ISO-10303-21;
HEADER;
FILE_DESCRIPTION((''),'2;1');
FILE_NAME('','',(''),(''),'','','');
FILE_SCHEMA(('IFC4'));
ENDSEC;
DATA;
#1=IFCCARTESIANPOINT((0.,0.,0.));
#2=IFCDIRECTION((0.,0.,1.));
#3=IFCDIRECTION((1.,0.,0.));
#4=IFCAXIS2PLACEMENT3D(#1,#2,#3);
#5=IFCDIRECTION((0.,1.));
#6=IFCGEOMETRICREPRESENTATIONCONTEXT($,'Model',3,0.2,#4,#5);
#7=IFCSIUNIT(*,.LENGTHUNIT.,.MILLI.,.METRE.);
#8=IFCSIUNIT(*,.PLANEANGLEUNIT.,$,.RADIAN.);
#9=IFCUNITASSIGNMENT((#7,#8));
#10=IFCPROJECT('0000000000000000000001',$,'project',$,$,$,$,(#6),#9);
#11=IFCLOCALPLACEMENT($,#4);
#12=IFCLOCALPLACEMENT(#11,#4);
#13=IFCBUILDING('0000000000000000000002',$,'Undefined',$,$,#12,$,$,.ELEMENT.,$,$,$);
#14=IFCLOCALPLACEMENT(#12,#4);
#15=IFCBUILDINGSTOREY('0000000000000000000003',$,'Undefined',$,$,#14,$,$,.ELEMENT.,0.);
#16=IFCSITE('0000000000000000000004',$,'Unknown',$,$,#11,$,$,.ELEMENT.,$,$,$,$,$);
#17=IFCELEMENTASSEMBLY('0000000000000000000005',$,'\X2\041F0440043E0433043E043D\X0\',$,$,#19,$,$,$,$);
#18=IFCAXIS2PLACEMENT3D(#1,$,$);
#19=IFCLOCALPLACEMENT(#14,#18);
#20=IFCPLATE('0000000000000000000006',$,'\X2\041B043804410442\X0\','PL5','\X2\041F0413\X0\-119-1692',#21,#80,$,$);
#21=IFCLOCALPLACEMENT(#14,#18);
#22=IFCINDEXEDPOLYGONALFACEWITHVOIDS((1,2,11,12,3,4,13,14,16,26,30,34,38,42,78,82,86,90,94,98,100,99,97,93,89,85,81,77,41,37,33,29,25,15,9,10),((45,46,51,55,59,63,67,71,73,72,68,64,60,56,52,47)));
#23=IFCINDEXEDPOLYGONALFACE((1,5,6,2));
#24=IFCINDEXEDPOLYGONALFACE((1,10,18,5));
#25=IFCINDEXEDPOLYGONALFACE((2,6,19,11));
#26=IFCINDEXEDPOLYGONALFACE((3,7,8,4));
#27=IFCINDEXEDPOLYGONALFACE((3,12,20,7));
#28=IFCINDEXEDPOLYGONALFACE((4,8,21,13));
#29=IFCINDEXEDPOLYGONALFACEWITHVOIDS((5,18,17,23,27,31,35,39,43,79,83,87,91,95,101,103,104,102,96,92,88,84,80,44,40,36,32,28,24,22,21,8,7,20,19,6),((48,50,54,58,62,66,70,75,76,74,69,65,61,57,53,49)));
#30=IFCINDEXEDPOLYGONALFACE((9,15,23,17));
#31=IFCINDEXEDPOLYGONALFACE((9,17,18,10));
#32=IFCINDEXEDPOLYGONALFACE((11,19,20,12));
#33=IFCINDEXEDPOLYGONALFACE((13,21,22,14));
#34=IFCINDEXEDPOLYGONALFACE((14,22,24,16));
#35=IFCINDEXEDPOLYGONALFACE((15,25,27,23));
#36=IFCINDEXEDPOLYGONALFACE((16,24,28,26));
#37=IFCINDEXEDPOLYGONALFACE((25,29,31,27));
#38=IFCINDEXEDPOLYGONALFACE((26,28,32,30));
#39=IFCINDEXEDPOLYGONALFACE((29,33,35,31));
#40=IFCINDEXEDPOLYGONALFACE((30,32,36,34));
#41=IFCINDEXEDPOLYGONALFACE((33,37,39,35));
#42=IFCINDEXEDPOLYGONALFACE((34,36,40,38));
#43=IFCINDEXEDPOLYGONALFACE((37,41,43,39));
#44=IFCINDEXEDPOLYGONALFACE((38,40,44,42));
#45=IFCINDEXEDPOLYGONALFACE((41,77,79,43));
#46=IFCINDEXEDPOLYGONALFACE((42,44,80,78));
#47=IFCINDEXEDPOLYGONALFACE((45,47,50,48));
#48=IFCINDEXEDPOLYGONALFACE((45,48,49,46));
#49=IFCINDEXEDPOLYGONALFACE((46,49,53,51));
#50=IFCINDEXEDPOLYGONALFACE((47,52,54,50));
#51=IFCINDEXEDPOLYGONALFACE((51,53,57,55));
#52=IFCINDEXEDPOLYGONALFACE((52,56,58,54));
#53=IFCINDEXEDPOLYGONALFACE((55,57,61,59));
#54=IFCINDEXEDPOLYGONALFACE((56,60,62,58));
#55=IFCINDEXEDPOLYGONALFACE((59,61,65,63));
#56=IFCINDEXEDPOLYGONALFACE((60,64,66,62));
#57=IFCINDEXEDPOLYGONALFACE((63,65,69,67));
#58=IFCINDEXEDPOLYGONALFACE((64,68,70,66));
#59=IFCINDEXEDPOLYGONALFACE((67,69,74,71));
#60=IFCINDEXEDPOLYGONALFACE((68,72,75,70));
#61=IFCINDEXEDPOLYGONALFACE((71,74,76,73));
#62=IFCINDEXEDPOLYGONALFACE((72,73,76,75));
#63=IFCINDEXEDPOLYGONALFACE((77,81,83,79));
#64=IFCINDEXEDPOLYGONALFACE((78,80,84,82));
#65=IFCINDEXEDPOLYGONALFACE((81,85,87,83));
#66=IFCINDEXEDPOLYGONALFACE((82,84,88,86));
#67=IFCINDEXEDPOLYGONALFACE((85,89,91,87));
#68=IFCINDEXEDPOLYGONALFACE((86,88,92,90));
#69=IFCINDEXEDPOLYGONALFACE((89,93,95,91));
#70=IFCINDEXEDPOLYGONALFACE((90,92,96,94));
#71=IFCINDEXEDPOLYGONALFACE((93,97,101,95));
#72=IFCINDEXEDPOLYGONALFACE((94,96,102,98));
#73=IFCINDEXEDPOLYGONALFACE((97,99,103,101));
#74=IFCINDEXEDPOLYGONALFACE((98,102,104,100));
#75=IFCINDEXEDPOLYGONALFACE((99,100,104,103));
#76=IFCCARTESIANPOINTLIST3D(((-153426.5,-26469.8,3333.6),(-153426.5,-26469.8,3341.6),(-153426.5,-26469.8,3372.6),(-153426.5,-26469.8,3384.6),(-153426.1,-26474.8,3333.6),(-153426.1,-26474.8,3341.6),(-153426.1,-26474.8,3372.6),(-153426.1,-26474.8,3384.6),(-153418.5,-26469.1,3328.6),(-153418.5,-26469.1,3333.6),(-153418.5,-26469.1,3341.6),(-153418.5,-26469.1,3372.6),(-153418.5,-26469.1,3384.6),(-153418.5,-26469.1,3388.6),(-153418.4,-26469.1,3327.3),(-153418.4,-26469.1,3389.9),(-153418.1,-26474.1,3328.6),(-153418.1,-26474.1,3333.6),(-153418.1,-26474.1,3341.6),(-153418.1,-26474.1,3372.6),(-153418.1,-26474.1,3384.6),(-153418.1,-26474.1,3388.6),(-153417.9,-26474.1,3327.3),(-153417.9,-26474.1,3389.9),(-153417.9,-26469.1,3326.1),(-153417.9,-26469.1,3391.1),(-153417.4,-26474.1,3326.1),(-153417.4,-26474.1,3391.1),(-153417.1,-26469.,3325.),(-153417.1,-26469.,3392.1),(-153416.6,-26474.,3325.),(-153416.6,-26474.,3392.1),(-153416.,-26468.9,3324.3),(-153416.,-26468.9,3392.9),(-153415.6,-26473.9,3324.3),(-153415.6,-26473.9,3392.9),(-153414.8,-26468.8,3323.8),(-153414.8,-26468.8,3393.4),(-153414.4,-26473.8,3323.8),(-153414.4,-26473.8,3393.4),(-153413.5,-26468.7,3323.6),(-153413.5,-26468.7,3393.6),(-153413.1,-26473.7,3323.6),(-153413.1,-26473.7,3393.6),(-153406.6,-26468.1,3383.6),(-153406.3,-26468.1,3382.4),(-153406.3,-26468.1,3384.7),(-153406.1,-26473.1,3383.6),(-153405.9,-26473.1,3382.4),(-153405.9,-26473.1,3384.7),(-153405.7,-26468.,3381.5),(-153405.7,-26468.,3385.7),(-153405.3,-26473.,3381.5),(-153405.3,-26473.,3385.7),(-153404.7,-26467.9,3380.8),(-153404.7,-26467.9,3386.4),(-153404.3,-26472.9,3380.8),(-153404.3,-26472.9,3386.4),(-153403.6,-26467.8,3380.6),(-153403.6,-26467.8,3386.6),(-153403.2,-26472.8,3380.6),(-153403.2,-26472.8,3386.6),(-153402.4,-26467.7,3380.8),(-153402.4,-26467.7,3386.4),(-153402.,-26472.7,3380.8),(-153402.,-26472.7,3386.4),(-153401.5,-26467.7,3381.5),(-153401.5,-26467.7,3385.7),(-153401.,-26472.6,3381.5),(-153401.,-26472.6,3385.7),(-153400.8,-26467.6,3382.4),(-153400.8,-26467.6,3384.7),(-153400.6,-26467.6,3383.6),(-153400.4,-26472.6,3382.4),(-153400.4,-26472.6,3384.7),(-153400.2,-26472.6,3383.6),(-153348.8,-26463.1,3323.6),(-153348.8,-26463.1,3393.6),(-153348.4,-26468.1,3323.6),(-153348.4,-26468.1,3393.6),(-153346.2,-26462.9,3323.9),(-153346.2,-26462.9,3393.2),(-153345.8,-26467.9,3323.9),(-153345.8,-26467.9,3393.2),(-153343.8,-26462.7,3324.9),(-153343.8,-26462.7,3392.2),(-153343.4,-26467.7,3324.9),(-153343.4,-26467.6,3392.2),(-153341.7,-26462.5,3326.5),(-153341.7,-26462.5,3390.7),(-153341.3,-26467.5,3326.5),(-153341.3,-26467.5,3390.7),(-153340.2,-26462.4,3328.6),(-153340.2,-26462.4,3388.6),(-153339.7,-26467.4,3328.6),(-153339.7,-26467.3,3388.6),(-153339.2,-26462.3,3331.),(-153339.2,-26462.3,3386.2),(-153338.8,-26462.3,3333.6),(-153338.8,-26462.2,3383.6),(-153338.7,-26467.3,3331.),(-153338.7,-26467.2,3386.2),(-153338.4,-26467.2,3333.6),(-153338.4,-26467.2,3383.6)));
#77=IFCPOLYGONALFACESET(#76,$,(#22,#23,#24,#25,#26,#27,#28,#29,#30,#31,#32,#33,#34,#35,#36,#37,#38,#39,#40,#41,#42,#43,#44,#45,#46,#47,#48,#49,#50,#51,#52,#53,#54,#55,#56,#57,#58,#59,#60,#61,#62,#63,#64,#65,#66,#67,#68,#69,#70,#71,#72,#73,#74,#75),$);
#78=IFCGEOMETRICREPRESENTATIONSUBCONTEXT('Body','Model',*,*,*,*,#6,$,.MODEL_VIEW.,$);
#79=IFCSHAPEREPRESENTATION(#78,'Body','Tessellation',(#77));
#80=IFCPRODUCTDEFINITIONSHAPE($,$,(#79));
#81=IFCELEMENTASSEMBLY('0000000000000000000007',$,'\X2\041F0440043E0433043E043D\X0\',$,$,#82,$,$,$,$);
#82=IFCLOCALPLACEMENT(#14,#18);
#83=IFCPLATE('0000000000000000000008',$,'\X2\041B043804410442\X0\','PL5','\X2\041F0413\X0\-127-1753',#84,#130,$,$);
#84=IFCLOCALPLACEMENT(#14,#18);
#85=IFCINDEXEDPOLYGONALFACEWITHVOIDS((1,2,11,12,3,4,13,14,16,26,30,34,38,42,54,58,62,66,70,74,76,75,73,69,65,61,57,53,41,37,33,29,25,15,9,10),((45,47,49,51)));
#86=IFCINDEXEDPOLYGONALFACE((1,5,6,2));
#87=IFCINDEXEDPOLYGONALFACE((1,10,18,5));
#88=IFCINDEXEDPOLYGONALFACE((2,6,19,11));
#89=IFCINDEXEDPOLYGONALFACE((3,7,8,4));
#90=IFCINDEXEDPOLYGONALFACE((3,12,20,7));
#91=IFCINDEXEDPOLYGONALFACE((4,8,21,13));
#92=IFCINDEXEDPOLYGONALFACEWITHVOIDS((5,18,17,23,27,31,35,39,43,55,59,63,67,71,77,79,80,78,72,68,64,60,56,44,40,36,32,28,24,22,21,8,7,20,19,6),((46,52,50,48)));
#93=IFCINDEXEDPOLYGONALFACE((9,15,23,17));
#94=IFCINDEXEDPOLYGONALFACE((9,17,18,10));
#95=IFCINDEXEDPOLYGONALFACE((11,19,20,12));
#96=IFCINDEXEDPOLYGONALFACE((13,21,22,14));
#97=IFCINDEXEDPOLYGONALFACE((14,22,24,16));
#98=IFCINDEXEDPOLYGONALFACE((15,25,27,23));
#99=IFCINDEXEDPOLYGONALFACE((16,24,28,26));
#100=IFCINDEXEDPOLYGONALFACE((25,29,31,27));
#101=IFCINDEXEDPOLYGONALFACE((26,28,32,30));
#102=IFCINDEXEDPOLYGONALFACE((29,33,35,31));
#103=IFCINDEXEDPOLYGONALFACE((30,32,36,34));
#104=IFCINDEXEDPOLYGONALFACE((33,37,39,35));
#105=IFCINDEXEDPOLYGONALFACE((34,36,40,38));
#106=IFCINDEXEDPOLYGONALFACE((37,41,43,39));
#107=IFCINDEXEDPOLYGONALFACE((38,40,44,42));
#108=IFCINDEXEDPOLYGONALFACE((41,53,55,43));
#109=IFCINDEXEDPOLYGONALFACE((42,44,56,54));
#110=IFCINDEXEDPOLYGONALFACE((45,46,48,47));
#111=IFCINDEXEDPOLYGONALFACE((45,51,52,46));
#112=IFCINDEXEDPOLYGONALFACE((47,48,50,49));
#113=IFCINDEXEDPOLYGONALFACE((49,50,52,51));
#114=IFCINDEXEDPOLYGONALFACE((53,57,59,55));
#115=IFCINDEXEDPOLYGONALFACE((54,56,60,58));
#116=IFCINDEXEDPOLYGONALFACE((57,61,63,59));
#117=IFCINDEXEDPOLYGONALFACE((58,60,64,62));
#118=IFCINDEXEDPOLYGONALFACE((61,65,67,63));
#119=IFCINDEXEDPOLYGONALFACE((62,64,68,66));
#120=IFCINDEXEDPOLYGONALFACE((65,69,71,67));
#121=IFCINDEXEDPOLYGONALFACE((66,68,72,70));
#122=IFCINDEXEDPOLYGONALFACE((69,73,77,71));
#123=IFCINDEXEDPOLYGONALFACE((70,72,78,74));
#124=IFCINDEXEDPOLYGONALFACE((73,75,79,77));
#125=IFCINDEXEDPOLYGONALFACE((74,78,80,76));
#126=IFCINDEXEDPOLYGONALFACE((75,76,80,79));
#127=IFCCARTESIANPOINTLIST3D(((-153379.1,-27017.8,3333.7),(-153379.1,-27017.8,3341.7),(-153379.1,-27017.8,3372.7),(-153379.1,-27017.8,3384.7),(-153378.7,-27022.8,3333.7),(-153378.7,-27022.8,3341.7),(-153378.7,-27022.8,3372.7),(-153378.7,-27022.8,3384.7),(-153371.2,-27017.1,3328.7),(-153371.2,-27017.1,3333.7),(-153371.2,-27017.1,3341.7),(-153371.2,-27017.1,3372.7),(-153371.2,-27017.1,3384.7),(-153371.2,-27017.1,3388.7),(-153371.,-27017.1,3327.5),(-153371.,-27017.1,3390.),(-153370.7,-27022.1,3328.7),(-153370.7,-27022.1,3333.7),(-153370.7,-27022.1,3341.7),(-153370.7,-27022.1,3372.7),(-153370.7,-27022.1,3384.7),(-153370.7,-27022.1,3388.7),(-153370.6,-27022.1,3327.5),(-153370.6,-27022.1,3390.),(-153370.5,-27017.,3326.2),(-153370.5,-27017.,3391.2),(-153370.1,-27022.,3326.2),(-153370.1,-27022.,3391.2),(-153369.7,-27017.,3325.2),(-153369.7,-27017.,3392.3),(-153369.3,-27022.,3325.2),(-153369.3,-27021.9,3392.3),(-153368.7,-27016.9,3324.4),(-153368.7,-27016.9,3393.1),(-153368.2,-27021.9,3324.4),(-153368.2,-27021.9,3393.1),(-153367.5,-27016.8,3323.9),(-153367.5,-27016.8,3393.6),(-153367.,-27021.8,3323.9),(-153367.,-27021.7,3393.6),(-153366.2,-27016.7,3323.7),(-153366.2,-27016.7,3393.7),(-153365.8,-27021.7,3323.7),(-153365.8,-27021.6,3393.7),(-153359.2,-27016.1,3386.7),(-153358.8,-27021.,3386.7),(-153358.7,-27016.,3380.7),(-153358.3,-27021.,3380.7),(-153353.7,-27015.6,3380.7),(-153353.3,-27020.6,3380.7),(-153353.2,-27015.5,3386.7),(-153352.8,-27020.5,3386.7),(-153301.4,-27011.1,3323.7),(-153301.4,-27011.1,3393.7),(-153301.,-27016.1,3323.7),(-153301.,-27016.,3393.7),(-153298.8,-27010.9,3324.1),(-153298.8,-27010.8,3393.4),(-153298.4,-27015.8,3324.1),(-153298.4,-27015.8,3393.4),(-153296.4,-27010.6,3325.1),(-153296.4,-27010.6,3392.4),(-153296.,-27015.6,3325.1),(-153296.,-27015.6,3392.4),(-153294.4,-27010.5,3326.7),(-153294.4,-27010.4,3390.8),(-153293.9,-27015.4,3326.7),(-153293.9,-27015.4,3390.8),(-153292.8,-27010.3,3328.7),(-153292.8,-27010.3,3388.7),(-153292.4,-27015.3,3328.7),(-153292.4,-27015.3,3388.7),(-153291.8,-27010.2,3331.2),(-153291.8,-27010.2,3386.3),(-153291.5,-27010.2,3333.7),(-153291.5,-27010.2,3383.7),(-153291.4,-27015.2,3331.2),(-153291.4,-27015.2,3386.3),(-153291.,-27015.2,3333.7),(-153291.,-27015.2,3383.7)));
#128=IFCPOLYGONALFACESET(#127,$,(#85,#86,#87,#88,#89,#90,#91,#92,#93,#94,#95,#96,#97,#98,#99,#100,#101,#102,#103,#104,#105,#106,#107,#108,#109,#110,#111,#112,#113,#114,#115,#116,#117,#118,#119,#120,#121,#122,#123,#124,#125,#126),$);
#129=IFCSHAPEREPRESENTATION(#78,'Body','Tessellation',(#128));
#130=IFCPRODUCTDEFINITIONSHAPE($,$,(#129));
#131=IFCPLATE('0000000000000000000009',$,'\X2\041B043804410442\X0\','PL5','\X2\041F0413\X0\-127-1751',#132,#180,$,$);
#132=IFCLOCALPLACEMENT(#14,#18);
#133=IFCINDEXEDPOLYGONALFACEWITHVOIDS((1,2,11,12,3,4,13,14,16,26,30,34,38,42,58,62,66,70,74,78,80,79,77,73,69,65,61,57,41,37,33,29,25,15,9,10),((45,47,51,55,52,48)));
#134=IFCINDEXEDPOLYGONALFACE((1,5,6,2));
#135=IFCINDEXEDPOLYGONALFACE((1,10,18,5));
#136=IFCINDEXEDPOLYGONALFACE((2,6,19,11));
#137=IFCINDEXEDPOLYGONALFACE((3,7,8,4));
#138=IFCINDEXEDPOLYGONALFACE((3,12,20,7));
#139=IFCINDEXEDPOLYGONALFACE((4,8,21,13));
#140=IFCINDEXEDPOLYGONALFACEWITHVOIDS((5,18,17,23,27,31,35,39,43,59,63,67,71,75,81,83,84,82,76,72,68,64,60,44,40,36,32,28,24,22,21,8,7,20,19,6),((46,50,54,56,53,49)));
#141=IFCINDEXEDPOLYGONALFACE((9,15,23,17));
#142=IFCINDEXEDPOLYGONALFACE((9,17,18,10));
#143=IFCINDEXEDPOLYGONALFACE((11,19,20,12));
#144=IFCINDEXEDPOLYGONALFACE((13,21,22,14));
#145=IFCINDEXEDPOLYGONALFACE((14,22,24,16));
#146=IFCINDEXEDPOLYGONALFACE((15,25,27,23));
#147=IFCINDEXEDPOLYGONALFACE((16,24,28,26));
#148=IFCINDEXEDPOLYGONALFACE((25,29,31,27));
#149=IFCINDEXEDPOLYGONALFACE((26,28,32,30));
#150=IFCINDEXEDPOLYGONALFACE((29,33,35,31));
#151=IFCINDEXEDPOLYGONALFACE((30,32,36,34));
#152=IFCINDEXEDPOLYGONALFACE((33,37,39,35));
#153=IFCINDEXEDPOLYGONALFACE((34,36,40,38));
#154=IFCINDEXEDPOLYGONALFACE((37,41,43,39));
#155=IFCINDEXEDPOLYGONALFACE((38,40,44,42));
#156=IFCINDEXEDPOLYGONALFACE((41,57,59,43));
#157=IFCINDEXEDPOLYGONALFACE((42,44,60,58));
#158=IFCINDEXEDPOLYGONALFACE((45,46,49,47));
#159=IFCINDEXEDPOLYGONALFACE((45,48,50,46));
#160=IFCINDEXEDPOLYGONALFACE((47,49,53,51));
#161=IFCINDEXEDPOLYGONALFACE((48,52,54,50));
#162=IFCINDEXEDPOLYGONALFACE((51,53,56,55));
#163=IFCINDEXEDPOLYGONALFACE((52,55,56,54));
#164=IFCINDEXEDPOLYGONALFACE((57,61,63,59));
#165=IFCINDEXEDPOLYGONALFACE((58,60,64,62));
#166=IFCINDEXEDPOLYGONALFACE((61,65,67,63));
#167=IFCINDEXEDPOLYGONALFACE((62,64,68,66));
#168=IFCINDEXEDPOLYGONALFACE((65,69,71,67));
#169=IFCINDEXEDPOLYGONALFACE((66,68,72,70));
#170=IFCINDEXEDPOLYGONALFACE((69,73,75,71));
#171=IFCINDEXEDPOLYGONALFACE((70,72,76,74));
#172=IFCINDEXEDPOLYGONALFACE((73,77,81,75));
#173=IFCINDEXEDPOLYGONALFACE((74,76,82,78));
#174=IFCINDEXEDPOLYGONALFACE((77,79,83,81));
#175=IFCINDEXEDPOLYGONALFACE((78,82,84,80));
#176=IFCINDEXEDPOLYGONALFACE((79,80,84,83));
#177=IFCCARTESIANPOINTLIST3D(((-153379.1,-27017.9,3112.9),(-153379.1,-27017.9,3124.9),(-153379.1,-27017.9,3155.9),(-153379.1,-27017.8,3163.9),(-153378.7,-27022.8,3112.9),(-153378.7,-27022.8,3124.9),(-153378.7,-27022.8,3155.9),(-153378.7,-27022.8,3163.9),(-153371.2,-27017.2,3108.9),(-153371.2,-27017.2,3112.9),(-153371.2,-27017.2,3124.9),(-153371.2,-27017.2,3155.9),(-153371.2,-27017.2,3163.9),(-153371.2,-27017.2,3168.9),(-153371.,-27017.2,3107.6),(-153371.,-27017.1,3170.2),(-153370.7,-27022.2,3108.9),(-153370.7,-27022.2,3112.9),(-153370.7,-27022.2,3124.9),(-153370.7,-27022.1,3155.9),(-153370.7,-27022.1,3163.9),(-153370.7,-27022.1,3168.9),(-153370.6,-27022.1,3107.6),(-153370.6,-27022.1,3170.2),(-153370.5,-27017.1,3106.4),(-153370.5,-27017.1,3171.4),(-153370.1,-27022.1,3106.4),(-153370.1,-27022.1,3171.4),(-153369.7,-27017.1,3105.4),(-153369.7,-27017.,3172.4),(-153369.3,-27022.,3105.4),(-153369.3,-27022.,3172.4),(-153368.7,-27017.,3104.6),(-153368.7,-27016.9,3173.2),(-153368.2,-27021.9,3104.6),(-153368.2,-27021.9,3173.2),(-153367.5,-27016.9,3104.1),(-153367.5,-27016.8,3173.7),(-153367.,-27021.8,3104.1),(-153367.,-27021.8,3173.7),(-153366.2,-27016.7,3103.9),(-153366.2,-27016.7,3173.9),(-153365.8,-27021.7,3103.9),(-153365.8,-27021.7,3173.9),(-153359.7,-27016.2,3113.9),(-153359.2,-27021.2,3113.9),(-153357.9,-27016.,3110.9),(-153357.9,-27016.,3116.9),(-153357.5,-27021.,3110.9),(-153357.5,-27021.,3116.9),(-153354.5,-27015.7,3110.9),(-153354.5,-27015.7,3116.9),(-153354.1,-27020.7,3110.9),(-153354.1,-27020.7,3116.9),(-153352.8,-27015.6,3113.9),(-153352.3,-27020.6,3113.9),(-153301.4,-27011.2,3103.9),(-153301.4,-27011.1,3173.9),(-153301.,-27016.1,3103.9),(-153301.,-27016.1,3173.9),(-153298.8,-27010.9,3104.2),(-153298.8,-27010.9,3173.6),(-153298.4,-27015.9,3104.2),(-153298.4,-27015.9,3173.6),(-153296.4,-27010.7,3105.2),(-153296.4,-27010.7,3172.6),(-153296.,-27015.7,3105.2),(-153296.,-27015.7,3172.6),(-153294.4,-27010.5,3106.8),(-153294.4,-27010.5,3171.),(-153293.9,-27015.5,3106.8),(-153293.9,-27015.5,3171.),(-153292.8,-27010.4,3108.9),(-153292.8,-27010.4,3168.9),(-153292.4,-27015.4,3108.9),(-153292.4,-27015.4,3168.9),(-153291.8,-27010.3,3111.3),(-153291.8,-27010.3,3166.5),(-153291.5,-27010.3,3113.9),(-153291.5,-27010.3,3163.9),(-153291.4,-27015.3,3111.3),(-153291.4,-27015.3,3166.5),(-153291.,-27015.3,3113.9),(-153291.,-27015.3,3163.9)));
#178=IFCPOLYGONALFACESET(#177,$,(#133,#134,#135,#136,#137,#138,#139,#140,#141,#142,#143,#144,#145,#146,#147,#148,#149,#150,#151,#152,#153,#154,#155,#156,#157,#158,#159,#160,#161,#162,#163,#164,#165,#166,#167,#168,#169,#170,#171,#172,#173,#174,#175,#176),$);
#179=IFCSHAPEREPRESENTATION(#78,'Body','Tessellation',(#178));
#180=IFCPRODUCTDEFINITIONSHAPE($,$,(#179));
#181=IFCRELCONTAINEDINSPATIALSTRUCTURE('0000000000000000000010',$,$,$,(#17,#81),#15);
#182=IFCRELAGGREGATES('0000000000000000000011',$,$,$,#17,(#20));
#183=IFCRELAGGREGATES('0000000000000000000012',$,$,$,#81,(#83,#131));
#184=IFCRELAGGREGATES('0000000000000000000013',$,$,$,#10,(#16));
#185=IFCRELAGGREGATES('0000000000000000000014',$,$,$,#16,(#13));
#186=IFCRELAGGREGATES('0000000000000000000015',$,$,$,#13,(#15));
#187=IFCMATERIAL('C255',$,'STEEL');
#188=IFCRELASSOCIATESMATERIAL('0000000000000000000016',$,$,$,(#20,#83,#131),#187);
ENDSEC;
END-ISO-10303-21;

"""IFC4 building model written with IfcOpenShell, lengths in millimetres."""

from ifc_helpers import new_model, si_unit, direction, frame, origin_with_axes, place, context, subcontext, project, spatial, line, arc, indexed_curve, outline, extrude, material, element, aggregate, save


model = new_model("IFC4")

# Units and contexts
model_context = context("Model", 3, precision=0.2, world=origin_with_axes(), true_north=direction((0.0, 1.0)))
body_context = subcontext(model_context, "Body", "Model", "MODEL_VIEW")
ifc_project = project(units=[si_unit("LENGTHUNIT", "METRE", prefix="MILLI"), si_unit("PLANEANGLEUNIT", "RADIAN")], contexts=[model_context])

# Site, building, storey
site_placement = place(None, origin_with_axes())
site = spatial("IfcSite", under=ifc_project, at=site_placement, Name="Unknown", CompositionType="ELEMENT")
building_placement = place(site_placement, origin_with_axes())
building = spatial("IfcBuilding", under=site, at=building_placement, Name="Undefined", CompositionType="ELEMENT")
storey_placement = place(building_placement, origin_with_axes())
storey = spatial("IfcBuildingStorey", under=building, at=storey_placement, Name="Undefined", CompositionType="ELEMENT", Elevation=0.0)

# Shared definitions
ifc_material_1 = material(Name="C255", Category="STEEL")

# Element assembly, plate, voiding feature
assembly_1_placement = place(storey_placement, frame((-153458.2, -26475.1, 3063.5), z_axis=(0.086114, -0.996285, 0.0), x_axis=(0.0, 0.0, 1.0)))
assembly_1 = element("IfcElementAssembly", 1, at=assembly_1_placement, inside=storey, Name="Прогон")
plate_1_placement = place(assembly_1_placement, frame((260.1, -120.0, 0.0), z_axis=(0.000303, -0.000057, 1.0), x_axis=(1.0, 0.00003, -0.000303)))
plate_1 = element("IfcPlate", 2, at=plate_1_placement, material=ifc_material_1, Name="Лист", Description="PL5", ObjectType="ПГ-119-1692", context=body_context, shape_type="SolidModel", body=[
    extrude(outline(indexed_curve([(0.0, 10.0), (2.9, 2.9), (10.0, 0.0), (60.0, 0.0), (67.1, 2.9), (70.0, 10.0), (70.0, 75.0), (68.5, 78.5), (65.0, 80.0), (61.0, 80.0), (61.0, 88.0), (49.0, 88.0), (49.0, 80.0), (18.0, 80.0), (18.0, 88.0), (10.0, 88.0), (10.0, 80.0), (5.0, 80.0), (1.5, 78.5), (0.0, 75.0)], segments=[arc(1, 2, 3), line(3, 4), arc(4, 5, 6), line(6, 7), arc(7, 8, 9), line(9, 10, 11, 12, 13, 14, 15, 16, 17, 18), arc(18, 19, 20), line(20, 1)])), frame((0.0, 0.0, 2.5), z_axis=(0.0, 0.0, 1.0), x_axis=(1.0, 0.0, 0.0)), (0.0, 0.0, -1.0), 5.0),
])
voiding_feature_1_placement = place(plate_1_placement, frame((60.0, 65.0, 6.0), z_axis=(-0.000054, -1.0, 0.000034), x_axis=(0.0, -0.000034, -1.0)))
element("IfcVoidingFeature", 3, at=voiding_feature_1_placement, cuts=plate_1, Name="Балка", ObjectType="(?)", PredefinedType="HOLE", context=body_context, shape_type="SolidModel", body=[
    extrude(outline(indexed_curve([(3.0, 0.0), (2.8, 1.1), (2.1, 2.1), (1.1, 2.8), (0.0, 3.0), (-1.1, 2.8), (-2.1, 2.1), (-2.8, 1.1), (-3.0, 0.0), (-2.8, -1.1), (-2.1, -2.1), (-1.1, -2.8), (0.0, -3.0), (1.1, -2.8), (2.1, -2.1), (2.8, -1.1)], segments=[line(1, 2, 3, 4, 5, 6, 7, 8, 9, 10, 11, 12, 13, 14, 15, 16, 1)])), frame((0.0, 0.0, 0.0), z_axis=(-1.0, 0.0, 0.0), x_axis=(0.0, 0.0, 1.0)), (0.0, 0.0, -1.0), 12.0),
])
aggregate(assembly_1, [plate_1])

# Element assembly, plates, voiding features
assembly_2_placement = place(storey_placement, frame((-153410.8, -27023.1, 3063.5), z_axis=(0.086114, -0.996285, 0.0), x_axis=(0.0, 0.0, 1.0)))
assembly_2 = element("IfcElementAssembly", 4, at=assembly_2_placement, inside=storey, Name="Прогон")
plate_2_placement = place(assembly_2_placement, frame((260.2, -120.0, 0.0), z_axis=(0.000303, -0.000057, 1.0), x_axis=(1.0, 0.00003, -0.000303)))
plate_2 = element("IfcPlate", 5, at=plate_2_placement, material=ifc_material_1, Name="Лист", Description="PL5", ObjectType="ПГ-127-1753", context=body_context, shape_type="SolidModel", body=[
    extrude(outline(indexed_curve([(0.0, 10.0), (2.9, 2.9), (10.0, 0.0), (60.0, 0.0), (67.1, 2.9), (70.0, 10.0), (70.0, 75.0), (68.5, 78.5), (65.0, 80.0), (61.0, 80.0), (61.0, 88.0), (49.0, 88.0), (49.0, 80.0), (18.0, 80.0), (18.0, 88.0), (10.0, 88.0), (10.0, 80.0), (5.0, 80.0), (1.5, 78.5), (0.0, 75.0)], segments=[arc(1, 2, 3), line(3, 4), arc(4, 5, 6), line(6, 7), arc(7, 8, 9), line(9, 10, 11, 12, 13, 14, 15, 16, 17, 18), arc(18, 19, 20), line(20, 1)])), frame((0.0, 0.0, 2.5), z_axis=(0.0, 0.0, 1.0), x_axis=(1.0, 0.0, 0.0)), (0.0, 0.0, -1.0), 5.0),
])
voiding_feature_2_placement = place(plate_2_placement, frame((60.0, 65.0, 6.0), z_axis=(-0.000054, -1.0, 0.000034), x_axis=(0.0, -0.000034, -1.0)))
element("IfcVoidingFeature", 6, at=voiding_feature_2_placement, cuts=plate_2, Name="Балка", ObjectType="(?)", PredefinedType="HOLE", context=body_context, shape_type="SolidModel", body=[
    extrude(outline(indexed_curve([(2.5, -3.0), (3.0, 3.0), (-3.0, 3.0), (-2.5, -3.0)], segments=[line(1, 2, 3, 4, 1)])), frame((0.0, 0.0, 0.0), z_axis=(-1.0, 0.0, 0.0), x_axis=(0.0, 0.0, 1.0)), (0.0, 0.0, -1.0), 12.0),
])
plate_3_placement = place(assembly_2_placement, frame((110.4, -120.0, 0.0), z_axis=(-0.000303, -0.000057, -1.0), x_axis=(-1.0, 0.000078, 0.000303)))
plate_3 = element("IfcPlate", 7, at=plate_3_placement, material=ifc_material_1, Name="Лист", Description="PL5", ObjectType="ПГ-127-1751", context=body_context, shape_type="SolidModel", body=[
    extrude(outline(indexed_curve([(0.0, 10.0), (2.9, 2.9), (10.0, 0.0), (60.0, 0.0), (67.1, 2.9), (70.0, 10.0), (70.0, 75.0), (68.5, 78.5), (65.0, 80.0), (61.0, 80.0), (61.0, 88.0), (49.0, 88.0), (49.0, 80.0), (18.0, 80.0), (18.0, 88.0), (10.0, 88.0), (10.0, 80.0), (5.0, 80.0), (1.5, 78.5), (0.0, 75.0)], segments=[arc(1, 2, 3), line(3, 4), arc(4, 5, 6), line(6, 7), arc(7, 8, 9), line(9, 10, 11, 12, 13, 14, 15, 16, 17, 18), arc(18, 19, 20), line(20, 1)])), frame((0.0, 0.0, 2.5), z_axis=(0.0, 0.0, 1.0), x_axis=(1.0, 0.0, 0.0)), (0.0, 0.0, -1.0), 5.0),
])
voiding_feature_3_placement = place(plate_3_placement, frame((60.0, 65.0, 6.0), z_axis=(-0.000054, -1.0, 0.000034), x_axis=(0.0, -0.000034, -1.0)))
element("IfcVoidingFeature", 8, at=voiding_feature_3_placement, cuts=plate_3, Name="Балка", ObjectType="(?)", PredefinedType="HOLE", context=body_context, shape_type="SolidModel", body=[
    extrude(outline(indexed_curve([(1.7, -3.0), (3.5, 0.0), (1.7, 3.0), (-1.7, 3.0), (-3.5, 0.0), (-1.7, -3.0)], segments=[line(1, 2, 3, 4, 5, 6, 1)])), frame((0.0, 0.0, 0.0), z_axis=(-1.0, 0.0, 0.0), x_axis=(0.0, 0.0, 1.0)), (0.0, 0.0, -1.0), 12.0),
])
aggregate(assembly_2, [plate_2, plate_3])

save(model, "model.ifc")
